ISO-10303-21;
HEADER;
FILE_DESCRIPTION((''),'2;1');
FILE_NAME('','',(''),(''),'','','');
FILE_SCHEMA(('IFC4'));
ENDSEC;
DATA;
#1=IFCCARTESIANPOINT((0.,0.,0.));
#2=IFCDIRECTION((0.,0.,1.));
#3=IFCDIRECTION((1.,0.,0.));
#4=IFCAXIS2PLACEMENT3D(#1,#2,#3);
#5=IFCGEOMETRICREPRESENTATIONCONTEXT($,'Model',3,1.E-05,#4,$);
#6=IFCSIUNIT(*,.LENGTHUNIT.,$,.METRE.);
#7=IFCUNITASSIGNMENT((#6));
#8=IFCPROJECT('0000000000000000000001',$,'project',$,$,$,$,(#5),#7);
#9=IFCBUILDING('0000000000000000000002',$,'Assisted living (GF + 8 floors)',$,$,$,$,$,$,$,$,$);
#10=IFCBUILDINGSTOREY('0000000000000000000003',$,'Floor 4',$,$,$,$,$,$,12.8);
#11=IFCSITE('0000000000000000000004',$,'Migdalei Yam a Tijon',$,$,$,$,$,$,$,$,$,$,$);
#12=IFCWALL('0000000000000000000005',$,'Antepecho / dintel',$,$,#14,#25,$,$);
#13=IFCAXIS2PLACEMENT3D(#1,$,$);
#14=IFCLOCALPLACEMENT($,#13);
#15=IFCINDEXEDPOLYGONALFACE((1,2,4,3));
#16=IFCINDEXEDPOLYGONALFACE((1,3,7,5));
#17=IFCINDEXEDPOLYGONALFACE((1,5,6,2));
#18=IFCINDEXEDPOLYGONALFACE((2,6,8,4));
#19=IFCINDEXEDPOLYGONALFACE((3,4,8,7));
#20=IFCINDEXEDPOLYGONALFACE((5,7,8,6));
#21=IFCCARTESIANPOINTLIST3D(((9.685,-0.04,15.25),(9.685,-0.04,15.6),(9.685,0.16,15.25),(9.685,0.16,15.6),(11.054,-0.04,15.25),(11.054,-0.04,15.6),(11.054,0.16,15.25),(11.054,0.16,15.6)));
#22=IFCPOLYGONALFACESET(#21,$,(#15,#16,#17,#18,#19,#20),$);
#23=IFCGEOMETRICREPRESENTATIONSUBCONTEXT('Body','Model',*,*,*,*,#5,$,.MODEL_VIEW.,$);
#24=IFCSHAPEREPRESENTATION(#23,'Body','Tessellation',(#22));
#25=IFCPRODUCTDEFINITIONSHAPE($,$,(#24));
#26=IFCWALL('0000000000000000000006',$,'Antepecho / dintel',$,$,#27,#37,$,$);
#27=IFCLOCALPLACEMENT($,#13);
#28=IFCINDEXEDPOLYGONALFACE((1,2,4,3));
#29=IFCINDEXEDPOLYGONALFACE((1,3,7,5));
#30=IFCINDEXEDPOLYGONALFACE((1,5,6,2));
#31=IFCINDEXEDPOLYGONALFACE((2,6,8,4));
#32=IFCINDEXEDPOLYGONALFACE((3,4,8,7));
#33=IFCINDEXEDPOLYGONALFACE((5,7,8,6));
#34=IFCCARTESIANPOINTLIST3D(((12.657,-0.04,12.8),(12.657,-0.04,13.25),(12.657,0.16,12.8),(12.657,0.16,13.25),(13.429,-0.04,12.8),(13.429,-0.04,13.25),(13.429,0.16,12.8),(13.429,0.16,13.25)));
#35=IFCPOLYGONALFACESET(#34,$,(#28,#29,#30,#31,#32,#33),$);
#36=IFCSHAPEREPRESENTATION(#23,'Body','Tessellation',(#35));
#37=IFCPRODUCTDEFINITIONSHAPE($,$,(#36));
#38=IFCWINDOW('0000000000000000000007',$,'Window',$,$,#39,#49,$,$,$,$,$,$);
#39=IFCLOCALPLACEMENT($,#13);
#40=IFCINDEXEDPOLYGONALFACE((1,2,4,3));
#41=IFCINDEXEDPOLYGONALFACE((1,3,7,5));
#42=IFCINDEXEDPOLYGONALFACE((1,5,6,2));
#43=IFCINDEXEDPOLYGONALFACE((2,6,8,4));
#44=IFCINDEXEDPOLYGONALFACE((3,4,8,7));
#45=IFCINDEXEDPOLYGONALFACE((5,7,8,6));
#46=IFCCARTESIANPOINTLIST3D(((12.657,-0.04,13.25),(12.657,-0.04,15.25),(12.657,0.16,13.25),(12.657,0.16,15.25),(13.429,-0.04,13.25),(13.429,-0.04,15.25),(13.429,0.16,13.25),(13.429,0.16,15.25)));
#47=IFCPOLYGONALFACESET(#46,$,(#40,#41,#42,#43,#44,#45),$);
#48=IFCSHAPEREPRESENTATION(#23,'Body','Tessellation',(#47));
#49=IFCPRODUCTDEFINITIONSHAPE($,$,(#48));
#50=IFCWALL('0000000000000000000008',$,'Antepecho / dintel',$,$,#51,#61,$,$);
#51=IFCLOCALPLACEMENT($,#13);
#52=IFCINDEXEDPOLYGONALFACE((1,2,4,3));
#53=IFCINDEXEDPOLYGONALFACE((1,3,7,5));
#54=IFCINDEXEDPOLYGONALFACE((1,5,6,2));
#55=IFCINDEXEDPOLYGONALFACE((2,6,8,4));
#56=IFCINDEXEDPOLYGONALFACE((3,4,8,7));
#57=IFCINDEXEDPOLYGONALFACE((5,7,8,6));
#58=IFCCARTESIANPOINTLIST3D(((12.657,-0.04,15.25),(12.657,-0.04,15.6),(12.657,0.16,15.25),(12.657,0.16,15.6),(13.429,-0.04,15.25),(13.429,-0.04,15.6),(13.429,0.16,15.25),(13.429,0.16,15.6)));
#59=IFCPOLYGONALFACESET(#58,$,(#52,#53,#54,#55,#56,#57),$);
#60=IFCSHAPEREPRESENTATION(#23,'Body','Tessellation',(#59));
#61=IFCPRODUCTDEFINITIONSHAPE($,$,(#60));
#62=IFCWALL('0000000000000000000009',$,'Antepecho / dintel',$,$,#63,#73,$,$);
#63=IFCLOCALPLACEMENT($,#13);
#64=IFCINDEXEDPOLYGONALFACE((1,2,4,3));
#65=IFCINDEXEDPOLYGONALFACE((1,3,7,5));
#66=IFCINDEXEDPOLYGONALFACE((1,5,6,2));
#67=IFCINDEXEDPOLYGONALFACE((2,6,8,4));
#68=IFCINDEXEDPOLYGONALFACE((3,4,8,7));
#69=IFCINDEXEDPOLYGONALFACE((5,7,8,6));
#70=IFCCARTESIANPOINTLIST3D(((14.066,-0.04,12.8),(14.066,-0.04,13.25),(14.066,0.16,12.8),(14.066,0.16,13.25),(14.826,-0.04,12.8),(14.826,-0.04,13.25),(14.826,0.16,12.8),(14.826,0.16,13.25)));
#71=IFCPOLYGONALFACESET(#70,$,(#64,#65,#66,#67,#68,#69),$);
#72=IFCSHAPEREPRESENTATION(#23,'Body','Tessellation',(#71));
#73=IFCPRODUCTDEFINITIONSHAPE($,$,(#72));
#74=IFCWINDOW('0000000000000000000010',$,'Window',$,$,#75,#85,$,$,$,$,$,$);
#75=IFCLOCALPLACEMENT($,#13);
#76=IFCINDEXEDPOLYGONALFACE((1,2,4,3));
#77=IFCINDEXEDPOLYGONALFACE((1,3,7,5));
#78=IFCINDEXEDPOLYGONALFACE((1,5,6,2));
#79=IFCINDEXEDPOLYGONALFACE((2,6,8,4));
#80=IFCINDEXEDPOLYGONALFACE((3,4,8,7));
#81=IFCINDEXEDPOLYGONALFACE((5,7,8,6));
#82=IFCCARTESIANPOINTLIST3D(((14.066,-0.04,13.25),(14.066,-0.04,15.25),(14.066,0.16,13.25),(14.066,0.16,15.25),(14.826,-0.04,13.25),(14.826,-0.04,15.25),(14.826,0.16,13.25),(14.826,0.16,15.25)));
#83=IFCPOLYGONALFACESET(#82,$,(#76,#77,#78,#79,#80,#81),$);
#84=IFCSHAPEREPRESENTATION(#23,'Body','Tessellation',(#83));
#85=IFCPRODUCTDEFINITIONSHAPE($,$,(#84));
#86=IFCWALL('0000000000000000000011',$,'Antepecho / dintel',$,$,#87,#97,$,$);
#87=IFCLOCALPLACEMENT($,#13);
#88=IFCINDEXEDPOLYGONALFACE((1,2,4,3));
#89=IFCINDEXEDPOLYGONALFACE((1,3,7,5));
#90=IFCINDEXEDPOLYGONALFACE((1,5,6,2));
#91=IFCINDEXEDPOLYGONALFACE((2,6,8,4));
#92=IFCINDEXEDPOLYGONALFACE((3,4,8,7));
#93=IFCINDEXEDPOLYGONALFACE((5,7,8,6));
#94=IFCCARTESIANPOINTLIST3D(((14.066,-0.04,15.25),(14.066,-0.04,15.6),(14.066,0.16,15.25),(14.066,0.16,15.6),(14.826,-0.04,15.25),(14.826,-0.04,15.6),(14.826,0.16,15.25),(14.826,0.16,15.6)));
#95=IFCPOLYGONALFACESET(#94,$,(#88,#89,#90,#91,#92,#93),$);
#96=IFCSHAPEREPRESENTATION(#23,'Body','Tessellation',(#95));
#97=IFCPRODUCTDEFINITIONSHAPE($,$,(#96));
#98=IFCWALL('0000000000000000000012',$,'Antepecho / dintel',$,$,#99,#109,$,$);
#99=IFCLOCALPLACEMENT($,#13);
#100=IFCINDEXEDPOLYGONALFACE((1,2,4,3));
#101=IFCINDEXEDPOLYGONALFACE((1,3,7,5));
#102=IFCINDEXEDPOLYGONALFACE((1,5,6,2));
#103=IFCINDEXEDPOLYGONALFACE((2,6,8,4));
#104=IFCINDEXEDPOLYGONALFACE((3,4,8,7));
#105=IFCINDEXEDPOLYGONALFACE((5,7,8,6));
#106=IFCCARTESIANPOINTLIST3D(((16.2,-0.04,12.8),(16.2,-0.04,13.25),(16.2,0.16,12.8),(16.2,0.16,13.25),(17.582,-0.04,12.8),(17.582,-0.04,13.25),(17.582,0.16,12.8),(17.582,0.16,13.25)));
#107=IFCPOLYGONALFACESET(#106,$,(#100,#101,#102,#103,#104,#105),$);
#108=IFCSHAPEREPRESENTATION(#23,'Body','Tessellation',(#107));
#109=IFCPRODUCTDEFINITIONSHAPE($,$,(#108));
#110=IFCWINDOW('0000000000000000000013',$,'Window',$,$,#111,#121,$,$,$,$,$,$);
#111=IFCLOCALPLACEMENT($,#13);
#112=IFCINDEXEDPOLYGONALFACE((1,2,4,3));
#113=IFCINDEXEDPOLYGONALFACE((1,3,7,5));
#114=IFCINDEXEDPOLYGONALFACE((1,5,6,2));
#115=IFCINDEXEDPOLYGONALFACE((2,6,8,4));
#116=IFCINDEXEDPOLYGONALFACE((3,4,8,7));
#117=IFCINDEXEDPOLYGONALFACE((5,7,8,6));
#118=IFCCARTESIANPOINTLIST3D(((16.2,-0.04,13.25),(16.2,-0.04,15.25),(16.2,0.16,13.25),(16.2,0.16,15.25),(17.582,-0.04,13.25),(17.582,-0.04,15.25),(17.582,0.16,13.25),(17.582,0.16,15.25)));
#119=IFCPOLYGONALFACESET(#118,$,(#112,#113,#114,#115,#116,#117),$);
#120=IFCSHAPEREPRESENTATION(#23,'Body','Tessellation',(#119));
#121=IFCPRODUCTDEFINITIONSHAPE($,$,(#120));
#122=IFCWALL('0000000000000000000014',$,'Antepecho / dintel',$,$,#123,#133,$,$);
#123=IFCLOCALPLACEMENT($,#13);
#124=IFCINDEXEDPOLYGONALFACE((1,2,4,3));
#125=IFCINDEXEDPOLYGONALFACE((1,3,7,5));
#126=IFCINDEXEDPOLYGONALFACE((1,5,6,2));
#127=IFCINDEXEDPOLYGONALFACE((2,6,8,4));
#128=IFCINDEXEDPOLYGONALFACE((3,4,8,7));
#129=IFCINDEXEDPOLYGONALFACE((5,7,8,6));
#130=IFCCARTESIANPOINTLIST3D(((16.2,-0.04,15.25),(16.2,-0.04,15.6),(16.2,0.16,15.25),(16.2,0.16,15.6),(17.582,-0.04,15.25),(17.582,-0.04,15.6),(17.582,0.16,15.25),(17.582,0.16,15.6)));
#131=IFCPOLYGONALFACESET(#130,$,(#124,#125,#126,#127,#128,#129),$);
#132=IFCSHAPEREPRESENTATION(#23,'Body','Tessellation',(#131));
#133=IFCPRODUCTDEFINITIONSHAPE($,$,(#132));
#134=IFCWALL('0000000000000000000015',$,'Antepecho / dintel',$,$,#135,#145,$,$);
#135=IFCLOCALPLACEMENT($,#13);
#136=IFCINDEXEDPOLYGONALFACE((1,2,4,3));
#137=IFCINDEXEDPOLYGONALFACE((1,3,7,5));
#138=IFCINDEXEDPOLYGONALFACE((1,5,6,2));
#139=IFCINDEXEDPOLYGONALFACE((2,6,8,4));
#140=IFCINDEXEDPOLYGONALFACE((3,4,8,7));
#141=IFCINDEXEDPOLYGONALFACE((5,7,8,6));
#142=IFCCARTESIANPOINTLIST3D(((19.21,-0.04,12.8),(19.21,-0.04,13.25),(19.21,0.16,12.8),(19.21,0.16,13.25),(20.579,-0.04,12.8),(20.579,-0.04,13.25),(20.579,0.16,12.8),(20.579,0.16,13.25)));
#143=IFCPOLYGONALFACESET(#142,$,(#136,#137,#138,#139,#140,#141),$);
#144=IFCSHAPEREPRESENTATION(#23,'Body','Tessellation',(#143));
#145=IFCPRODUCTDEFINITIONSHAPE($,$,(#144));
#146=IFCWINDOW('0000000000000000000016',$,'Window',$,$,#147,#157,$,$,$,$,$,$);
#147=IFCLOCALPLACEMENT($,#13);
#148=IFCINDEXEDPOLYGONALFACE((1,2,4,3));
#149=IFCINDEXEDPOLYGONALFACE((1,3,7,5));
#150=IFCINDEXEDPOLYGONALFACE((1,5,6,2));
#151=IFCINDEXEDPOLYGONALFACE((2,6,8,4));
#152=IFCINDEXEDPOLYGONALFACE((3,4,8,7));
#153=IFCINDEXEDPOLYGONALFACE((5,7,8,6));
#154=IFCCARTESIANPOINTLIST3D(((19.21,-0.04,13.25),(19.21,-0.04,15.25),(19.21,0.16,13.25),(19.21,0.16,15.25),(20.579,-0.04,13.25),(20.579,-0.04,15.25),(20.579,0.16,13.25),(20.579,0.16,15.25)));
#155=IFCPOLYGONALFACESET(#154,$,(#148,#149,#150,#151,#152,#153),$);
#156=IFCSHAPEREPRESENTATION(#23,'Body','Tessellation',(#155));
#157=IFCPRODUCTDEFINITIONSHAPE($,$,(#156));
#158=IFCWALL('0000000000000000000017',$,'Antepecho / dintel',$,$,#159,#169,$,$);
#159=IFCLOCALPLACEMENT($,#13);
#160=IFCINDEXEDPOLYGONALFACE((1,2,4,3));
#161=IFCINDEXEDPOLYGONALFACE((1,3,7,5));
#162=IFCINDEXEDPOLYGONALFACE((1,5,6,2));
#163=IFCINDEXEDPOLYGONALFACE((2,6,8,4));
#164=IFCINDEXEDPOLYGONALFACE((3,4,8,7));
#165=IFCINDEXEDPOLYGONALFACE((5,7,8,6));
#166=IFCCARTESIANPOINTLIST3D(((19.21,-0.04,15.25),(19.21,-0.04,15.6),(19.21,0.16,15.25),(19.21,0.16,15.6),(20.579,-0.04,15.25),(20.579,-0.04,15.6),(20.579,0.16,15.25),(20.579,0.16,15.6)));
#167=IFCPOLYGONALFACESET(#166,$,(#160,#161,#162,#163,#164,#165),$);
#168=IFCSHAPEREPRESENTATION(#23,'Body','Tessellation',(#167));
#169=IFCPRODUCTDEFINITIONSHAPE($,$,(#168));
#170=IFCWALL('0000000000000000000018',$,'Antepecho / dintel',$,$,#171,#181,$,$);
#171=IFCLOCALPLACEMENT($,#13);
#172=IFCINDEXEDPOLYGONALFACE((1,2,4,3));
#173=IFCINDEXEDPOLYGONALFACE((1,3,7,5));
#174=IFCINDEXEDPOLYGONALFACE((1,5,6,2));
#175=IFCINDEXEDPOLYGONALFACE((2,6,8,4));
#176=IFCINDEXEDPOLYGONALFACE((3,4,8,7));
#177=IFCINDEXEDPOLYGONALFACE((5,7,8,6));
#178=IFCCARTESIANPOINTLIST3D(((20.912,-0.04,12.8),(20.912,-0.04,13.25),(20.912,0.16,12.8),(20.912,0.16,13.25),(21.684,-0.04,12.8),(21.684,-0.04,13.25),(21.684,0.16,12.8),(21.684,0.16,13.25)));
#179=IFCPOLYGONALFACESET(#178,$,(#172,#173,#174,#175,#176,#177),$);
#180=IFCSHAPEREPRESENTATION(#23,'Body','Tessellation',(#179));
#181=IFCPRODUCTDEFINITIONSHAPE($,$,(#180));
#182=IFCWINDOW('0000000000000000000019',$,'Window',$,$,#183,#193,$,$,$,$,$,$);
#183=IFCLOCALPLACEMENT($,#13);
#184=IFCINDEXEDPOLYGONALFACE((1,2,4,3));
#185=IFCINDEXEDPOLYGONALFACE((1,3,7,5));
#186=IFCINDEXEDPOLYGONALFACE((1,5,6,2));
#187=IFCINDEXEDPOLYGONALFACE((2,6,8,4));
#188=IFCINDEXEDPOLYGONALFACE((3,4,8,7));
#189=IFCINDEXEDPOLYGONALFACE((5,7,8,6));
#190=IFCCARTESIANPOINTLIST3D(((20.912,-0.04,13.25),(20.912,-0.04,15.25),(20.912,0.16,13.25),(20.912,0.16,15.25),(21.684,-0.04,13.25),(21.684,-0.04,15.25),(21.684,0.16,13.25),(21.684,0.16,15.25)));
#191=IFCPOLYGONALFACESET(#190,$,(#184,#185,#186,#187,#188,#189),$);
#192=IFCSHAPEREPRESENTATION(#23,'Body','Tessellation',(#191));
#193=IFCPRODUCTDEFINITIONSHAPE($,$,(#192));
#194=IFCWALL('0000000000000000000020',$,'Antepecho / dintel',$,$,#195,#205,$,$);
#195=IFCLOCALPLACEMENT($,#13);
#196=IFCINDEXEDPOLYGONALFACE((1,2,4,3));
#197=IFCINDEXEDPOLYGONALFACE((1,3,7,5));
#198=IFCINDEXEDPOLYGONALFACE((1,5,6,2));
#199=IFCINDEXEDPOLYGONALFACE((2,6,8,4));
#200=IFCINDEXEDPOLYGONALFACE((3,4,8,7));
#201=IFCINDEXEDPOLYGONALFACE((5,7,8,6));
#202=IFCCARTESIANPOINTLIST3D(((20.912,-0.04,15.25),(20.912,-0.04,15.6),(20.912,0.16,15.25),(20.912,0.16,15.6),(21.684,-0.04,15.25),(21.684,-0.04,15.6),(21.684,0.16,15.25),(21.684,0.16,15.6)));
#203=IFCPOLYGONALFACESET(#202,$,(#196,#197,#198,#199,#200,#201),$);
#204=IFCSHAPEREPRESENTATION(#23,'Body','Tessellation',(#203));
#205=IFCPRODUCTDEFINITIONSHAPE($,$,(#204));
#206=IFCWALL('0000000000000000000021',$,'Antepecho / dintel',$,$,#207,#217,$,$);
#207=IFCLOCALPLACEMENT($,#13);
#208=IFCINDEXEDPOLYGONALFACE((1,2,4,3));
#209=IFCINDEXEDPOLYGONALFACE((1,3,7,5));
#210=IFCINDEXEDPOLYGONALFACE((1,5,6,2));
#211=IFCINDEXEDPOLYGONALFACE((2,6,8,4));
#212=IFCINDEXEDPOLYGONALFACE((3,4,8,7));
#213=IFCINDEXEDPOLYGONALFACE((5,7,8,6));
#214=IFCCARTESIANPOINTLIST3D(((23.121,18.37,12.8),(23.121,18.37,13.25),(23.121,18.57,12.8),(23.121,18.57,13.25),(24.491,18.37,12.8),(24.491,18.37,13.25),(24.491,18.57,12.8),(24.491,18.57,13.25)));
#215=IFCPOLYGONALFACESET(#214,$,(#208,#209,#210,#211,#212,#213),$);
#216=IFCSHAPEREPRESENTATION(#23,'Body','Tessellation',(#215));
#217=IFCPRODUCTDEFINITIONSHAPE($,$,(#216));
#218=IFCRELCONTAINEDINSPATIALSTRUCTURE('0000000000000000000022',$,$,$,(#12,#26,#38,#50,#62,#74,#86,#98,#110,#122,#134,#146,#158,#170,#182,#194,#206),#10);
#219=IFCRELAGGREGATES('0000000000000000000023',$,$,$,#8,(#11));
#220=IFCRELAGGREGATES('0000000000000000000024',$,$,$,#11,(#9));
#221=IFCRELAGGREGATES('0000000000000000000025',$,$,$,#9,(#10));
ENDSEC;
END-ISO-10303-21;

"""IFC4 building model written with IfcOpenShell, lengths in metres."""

from ifc_helpers import new_model, si_unit, frame, origin_with_axes, context, subcontext, project, spatial, line, indexed_curve, outline, extrude, element, save


model = new_model("IFC4")

# Units and contexts
model_context = context("Model", 3, precision=1e-05, world=origin_with_axes())
body_context = subcontext(model_context, "Body", "Model", "MODEL_VIEW")
ifc_project = project(units=[si_unit("LENGTHUNIT", "METRE")], contexts=[model_context])

# Site, building, storey
site = spatial("IfcSite", under=ifc_project, Name="Migdalei Yam a Tijon")
building = spatial("IfcBuilding", under=site, Name="Assisted living (GF + 8 floors)")
storey = spatial("IfcBuildingStorey", under=building, Name="Floor 4", Elevation=12.8)

# Walls
element("IfcWall", 1, inside=storey, Name="Antepecho / dintel", context=body_context, shape_type="SweptSolid", body=[
    extrude(outline(indexed_curve([(0.0, 0.0), (1.369, 0.0), (1.369, 0.2), (0.0, 0.2)], segments=[line(1, 2, 3, 4, 1)])), frame((9.685, -0.04, 15.25), z_axis=(0.0, 0.0, 1.0), x_axis=(1.0, 0.0, 0.0)), (0.0, 0.0, 1.0), 0.35),
])
element("IfcWall", 2, inside=storey, Name="Antepecho / dintel", context=body_context, shape_type="SweptSolid", body=[
    extrude(outline(indexed_curve([(0.0, 0.0), (0.772, 0.0), (0.772, 0.2), (0.0, 0.2)], segments=[line(1, 2, 3, 4, 1)])), frame((12.657, -0.04, 12.8), z_axis=(0.0, 0.0, 1.0), x_axis=(1.0, 0.0, 0.0)), (0.0, 0.0, 1.0), 0.45),
])

# Window
element("IfcWindow", 3, inside=storey, Name="Window", context=body_context, shape_type="SweptSolid", body=[
    extrude(outline(indexed_curve([(0.0, 0.0), (0.772, 0.0), (0.772, 0.2), (0.0, 0.2)], segments=[line(1, 2, 3, 4, 1)])), frame((12.657, -0.04, 13.25), z_axis=(0.0, 0.0, 1.0), x_axis=(1.0, 0.0, 0.0)), (0.0, 0.0, 1.0), 2.0),
])

# Walls
element("IfcWall", 4, inside=storey, Name="Antepecho / dintel", context=body_context, shape_type="SweptSolid", body=[
    extrude(outline(indexed_curve([(0.0, 0.0), (0.772, 0.0), (0.772, 0.2), (0.0, 0.2)], segments=[line(1, 2, 3, 4, 1)])), frame((12.657, -0.04, 15.25), z_axis=(0.0, 0.0, 1.0), x_axis=(1.0, 0.0, 0.0)), (0.0, 0.0, 1.0), 0.35),
])
element("IfcWall", 5, inside=storey, Name="Antepecho / dintel", context=body_context, shape_type="SweptSolid", body=[
    extrude(outline(indexed_curve([(0.0, 0.0), (0.76, 0.0), (0.76, 0.2), (0.0, 0.2)], segments=[line(1, 2, 3, 4, 1)])), frame((14.066, -0.04, 12.8), z_axis=(0.0, 0.0, 1.0), x_axis=(1.0, 0.0, 0.0)), (0.0, 0.0, 1.0), 0.45),
])

# Window
element("IfcWindow", 6, inside=storey, Name="Window", context=body_context, shape_type="SweptSolid", body=[
    extrude(outline(indexed_curve([(0.0, 0.0), (0.76, 0.0), (0.76, 0.2), (0.0, 0.2)], segments=[line(1, 2, 3, 4, 1)])), frame((14.066, -0.04, 13.25), z_axis=(0.0, 0.0, 1.0), x_axis=(1.0, 0.0, 0.0)), (0.0, 0.0, 1.0), 2.0),
])

# Walls
element("IfcWall", 7, inside=storey, Name="Antepecho / dintel", context=body_context, shape_type="SweptSolid", body=[
    extrude(outline(indexed_curve([(0.0, 0.0), (0.76, 0.0), (0.76, 0.2), (0.0, 0.2)], segments=[line(1, 2, 3, 4, 1)])), frame((14.066, -0.04, 15.25), z_axis=(0.0, 0.0, 1.0), x_axis=(1.0, 0.0, 0.0)), (0.0, 0.0, 1.0), 0.35),
])
element("IfcWall", 8, inside=storey, Name="Antepecho / dintel", context=body_context, shape_type="SweptSolid", body=[
    extrude(outline(indexed_curve([(0.0, 0.0), (1.382, 0.0), (1.382, 0.2), (0.0, 0.2)], segments=[line(1, 2, 3, 4, 1)])), frame((16.2, -0.04, 12.8), z_axis=(0.0, 0.0, 1.0), x_axis=(1.0, 0.0, 0.0)), (0.0, 0.0, 1.0), 0.45),
])

# Window
element("IfcWindow", 9, inside=storey, Name="Window", context=body_context, shape_type="SweptSolid", body=[
    extrude(outline(indexed_curve([(0.0, 0.0), (1.382, 0.0), (1.382, 0.2), (0.0, 0.2)], segments=[line(1, 2, 3, 4, 1)])), frame((16.2, -0.04, 13.25), z_axis=(0.0, 0.0, 1.0), x_axis=(1.0, 0.0, 0.0)), (0.0, 0.0, 1.0), 2.0),
])

# Walls
element("IfcWall", 10, inside=storey, Name="Antepecho / dintel", context=body_context, shape_type="SweptSolid", body=[
    extrude(outline(indexed_curve([(0.0, 0.0), (1.382, 0.0), (1.382, 0.2), (0.0, 0.2)], segments=[line(1, 2, 3, 4, 1)])), frame((16.2, -0.04, 15.25), z_axis=(0.0, 0.0, 1.0), x_axis=(1.0, 0.0, 0.0)), (0.0, 0.0, 1.0), 0.35),
])
element("IfcWall", 11, inside=storey, Name="Antepecho / dintel", context=body_context, shape_type="SweptSolid", body=[
    extrude(outline(indexed_curve([(0.0, 0.0), (1.369, 0.0), (1.369, 0.2), (0.0, 0.2)], segments=[line(1, 2, 3, 4, 1)])), frame((19.21, -0.04, 12.8), z_axis=(0.0, 0.0, 1.0), x_axis=(1.0, 0.0, 0.0)), (0.0, 0.0, 1.0), 0.45),
])

# Window
element("IfcWindow", 12, inside=storey, Name="Window", context=body_context, shape_type="SweptSolid", body=[
    extrude(outline(indexed_curve([(0.0, 0.0), (1.369, 0.0), (1.369, 0.2), (0.0, 0.2)], segments=[line(1, 2, 3, 4, 1)])), frame((19.21, -0.04, 13.25), z_axis=(0.0, 0.0, 1.0), x_axis=(1.0, 0.0, 0.0)), (0.0, 0.0, 1.0), 2.0),
])

# Walls
element("IfcWall", 13, inside=storey, Name="Antepecho / dintel", context=body_context, shape_type="SweptSolid", body=[
    extrude(outline(indexed_curve([(0.0, 0.0), (1.369, 0.0), (1.369, 0.2), (0.0, 0.2)], segments=[line(1, 2, 3, 4, 1)])), frame((19.21, -0.04, 15.25), z_axis=(0.0, 0.0, 1.0), x_axis=(1.0, 0.0, 0.0)), (0.0, 0.0, 1.0), 0.35),
])
element("IfcWall", 14, inside=storey, Name="Antepecho / dintel", context=body_context, shape_type="SweptSolid", body=[
    extrude(outline(indexed_curve([(0.0, 0.0), (0.772, 0.0), (0.772, 0.2), (0.0, 0.2)], segments=[line(1, 2, 3, 4, 1)])), frame((20.912, -0.04, 12.8), z_axis=(0.0, 0.0, 1.0), x_axis=(1.0, 0.0, 0.0)), (0.0, 0.0, 1.0), 0.45),
])

# Window
element("IfcWindow", 15, inside=storey, Name="Window", context=body_context, shape_type="SweptSolid", body=[
    extrude(outline(indexed_curve([(0.0, 0.0), (0.772, 0.0), (0.772, 0.2), (0.0, 0.2)], segments=[line(1, 2, 3, 4, 1)])), frame((20.912, -0.04, 13.25), z_axis=(0.0, 0.0, 1.0), x_axis=(1.0, 0.0, 0.0)), (0.0, 0.0, 1.0), 2.0),
])

# Walls
element("IfcWall", 16, inside=storey, Name="Antepecho / dintel", context=body_context, shape_type="SweptSolid", body=[
    extrude(outline(indexed_curve([(0.0, 0.0), (0.772, 0.0), (0.772, 0.2), (0.0, 0.2)], segments=[line(1, 2, 3, 4, 1)])), frame((20.912, -0.04, 15.25), z_axis=(0.0, 0.0, 1.0), x_axis=(1.0, 0.0, 0.0)), (0.0, 0.0, 1.0), 0.35),
])
element("IfcWall", 17, inside=storey, Name="Antepecho / dintel", context=body_context, shape_type="SweptSolid", body=[
    extrude(outline(indexed_curve([(0.0, 0.0), (1.37, 0.0), (1.37, 0.2), (0.0, 0.2)], segments=[line(1, 2, 3, 4, 1)])), frame((23.121, 18.37, 12.8), z_axis=(0.0, 0.0, 1.0), x_axis=(1.0, 0.0, 0.0)), (0.0, 0.0, 1.0), 0.45),
])

save(model, "model.ifc")
